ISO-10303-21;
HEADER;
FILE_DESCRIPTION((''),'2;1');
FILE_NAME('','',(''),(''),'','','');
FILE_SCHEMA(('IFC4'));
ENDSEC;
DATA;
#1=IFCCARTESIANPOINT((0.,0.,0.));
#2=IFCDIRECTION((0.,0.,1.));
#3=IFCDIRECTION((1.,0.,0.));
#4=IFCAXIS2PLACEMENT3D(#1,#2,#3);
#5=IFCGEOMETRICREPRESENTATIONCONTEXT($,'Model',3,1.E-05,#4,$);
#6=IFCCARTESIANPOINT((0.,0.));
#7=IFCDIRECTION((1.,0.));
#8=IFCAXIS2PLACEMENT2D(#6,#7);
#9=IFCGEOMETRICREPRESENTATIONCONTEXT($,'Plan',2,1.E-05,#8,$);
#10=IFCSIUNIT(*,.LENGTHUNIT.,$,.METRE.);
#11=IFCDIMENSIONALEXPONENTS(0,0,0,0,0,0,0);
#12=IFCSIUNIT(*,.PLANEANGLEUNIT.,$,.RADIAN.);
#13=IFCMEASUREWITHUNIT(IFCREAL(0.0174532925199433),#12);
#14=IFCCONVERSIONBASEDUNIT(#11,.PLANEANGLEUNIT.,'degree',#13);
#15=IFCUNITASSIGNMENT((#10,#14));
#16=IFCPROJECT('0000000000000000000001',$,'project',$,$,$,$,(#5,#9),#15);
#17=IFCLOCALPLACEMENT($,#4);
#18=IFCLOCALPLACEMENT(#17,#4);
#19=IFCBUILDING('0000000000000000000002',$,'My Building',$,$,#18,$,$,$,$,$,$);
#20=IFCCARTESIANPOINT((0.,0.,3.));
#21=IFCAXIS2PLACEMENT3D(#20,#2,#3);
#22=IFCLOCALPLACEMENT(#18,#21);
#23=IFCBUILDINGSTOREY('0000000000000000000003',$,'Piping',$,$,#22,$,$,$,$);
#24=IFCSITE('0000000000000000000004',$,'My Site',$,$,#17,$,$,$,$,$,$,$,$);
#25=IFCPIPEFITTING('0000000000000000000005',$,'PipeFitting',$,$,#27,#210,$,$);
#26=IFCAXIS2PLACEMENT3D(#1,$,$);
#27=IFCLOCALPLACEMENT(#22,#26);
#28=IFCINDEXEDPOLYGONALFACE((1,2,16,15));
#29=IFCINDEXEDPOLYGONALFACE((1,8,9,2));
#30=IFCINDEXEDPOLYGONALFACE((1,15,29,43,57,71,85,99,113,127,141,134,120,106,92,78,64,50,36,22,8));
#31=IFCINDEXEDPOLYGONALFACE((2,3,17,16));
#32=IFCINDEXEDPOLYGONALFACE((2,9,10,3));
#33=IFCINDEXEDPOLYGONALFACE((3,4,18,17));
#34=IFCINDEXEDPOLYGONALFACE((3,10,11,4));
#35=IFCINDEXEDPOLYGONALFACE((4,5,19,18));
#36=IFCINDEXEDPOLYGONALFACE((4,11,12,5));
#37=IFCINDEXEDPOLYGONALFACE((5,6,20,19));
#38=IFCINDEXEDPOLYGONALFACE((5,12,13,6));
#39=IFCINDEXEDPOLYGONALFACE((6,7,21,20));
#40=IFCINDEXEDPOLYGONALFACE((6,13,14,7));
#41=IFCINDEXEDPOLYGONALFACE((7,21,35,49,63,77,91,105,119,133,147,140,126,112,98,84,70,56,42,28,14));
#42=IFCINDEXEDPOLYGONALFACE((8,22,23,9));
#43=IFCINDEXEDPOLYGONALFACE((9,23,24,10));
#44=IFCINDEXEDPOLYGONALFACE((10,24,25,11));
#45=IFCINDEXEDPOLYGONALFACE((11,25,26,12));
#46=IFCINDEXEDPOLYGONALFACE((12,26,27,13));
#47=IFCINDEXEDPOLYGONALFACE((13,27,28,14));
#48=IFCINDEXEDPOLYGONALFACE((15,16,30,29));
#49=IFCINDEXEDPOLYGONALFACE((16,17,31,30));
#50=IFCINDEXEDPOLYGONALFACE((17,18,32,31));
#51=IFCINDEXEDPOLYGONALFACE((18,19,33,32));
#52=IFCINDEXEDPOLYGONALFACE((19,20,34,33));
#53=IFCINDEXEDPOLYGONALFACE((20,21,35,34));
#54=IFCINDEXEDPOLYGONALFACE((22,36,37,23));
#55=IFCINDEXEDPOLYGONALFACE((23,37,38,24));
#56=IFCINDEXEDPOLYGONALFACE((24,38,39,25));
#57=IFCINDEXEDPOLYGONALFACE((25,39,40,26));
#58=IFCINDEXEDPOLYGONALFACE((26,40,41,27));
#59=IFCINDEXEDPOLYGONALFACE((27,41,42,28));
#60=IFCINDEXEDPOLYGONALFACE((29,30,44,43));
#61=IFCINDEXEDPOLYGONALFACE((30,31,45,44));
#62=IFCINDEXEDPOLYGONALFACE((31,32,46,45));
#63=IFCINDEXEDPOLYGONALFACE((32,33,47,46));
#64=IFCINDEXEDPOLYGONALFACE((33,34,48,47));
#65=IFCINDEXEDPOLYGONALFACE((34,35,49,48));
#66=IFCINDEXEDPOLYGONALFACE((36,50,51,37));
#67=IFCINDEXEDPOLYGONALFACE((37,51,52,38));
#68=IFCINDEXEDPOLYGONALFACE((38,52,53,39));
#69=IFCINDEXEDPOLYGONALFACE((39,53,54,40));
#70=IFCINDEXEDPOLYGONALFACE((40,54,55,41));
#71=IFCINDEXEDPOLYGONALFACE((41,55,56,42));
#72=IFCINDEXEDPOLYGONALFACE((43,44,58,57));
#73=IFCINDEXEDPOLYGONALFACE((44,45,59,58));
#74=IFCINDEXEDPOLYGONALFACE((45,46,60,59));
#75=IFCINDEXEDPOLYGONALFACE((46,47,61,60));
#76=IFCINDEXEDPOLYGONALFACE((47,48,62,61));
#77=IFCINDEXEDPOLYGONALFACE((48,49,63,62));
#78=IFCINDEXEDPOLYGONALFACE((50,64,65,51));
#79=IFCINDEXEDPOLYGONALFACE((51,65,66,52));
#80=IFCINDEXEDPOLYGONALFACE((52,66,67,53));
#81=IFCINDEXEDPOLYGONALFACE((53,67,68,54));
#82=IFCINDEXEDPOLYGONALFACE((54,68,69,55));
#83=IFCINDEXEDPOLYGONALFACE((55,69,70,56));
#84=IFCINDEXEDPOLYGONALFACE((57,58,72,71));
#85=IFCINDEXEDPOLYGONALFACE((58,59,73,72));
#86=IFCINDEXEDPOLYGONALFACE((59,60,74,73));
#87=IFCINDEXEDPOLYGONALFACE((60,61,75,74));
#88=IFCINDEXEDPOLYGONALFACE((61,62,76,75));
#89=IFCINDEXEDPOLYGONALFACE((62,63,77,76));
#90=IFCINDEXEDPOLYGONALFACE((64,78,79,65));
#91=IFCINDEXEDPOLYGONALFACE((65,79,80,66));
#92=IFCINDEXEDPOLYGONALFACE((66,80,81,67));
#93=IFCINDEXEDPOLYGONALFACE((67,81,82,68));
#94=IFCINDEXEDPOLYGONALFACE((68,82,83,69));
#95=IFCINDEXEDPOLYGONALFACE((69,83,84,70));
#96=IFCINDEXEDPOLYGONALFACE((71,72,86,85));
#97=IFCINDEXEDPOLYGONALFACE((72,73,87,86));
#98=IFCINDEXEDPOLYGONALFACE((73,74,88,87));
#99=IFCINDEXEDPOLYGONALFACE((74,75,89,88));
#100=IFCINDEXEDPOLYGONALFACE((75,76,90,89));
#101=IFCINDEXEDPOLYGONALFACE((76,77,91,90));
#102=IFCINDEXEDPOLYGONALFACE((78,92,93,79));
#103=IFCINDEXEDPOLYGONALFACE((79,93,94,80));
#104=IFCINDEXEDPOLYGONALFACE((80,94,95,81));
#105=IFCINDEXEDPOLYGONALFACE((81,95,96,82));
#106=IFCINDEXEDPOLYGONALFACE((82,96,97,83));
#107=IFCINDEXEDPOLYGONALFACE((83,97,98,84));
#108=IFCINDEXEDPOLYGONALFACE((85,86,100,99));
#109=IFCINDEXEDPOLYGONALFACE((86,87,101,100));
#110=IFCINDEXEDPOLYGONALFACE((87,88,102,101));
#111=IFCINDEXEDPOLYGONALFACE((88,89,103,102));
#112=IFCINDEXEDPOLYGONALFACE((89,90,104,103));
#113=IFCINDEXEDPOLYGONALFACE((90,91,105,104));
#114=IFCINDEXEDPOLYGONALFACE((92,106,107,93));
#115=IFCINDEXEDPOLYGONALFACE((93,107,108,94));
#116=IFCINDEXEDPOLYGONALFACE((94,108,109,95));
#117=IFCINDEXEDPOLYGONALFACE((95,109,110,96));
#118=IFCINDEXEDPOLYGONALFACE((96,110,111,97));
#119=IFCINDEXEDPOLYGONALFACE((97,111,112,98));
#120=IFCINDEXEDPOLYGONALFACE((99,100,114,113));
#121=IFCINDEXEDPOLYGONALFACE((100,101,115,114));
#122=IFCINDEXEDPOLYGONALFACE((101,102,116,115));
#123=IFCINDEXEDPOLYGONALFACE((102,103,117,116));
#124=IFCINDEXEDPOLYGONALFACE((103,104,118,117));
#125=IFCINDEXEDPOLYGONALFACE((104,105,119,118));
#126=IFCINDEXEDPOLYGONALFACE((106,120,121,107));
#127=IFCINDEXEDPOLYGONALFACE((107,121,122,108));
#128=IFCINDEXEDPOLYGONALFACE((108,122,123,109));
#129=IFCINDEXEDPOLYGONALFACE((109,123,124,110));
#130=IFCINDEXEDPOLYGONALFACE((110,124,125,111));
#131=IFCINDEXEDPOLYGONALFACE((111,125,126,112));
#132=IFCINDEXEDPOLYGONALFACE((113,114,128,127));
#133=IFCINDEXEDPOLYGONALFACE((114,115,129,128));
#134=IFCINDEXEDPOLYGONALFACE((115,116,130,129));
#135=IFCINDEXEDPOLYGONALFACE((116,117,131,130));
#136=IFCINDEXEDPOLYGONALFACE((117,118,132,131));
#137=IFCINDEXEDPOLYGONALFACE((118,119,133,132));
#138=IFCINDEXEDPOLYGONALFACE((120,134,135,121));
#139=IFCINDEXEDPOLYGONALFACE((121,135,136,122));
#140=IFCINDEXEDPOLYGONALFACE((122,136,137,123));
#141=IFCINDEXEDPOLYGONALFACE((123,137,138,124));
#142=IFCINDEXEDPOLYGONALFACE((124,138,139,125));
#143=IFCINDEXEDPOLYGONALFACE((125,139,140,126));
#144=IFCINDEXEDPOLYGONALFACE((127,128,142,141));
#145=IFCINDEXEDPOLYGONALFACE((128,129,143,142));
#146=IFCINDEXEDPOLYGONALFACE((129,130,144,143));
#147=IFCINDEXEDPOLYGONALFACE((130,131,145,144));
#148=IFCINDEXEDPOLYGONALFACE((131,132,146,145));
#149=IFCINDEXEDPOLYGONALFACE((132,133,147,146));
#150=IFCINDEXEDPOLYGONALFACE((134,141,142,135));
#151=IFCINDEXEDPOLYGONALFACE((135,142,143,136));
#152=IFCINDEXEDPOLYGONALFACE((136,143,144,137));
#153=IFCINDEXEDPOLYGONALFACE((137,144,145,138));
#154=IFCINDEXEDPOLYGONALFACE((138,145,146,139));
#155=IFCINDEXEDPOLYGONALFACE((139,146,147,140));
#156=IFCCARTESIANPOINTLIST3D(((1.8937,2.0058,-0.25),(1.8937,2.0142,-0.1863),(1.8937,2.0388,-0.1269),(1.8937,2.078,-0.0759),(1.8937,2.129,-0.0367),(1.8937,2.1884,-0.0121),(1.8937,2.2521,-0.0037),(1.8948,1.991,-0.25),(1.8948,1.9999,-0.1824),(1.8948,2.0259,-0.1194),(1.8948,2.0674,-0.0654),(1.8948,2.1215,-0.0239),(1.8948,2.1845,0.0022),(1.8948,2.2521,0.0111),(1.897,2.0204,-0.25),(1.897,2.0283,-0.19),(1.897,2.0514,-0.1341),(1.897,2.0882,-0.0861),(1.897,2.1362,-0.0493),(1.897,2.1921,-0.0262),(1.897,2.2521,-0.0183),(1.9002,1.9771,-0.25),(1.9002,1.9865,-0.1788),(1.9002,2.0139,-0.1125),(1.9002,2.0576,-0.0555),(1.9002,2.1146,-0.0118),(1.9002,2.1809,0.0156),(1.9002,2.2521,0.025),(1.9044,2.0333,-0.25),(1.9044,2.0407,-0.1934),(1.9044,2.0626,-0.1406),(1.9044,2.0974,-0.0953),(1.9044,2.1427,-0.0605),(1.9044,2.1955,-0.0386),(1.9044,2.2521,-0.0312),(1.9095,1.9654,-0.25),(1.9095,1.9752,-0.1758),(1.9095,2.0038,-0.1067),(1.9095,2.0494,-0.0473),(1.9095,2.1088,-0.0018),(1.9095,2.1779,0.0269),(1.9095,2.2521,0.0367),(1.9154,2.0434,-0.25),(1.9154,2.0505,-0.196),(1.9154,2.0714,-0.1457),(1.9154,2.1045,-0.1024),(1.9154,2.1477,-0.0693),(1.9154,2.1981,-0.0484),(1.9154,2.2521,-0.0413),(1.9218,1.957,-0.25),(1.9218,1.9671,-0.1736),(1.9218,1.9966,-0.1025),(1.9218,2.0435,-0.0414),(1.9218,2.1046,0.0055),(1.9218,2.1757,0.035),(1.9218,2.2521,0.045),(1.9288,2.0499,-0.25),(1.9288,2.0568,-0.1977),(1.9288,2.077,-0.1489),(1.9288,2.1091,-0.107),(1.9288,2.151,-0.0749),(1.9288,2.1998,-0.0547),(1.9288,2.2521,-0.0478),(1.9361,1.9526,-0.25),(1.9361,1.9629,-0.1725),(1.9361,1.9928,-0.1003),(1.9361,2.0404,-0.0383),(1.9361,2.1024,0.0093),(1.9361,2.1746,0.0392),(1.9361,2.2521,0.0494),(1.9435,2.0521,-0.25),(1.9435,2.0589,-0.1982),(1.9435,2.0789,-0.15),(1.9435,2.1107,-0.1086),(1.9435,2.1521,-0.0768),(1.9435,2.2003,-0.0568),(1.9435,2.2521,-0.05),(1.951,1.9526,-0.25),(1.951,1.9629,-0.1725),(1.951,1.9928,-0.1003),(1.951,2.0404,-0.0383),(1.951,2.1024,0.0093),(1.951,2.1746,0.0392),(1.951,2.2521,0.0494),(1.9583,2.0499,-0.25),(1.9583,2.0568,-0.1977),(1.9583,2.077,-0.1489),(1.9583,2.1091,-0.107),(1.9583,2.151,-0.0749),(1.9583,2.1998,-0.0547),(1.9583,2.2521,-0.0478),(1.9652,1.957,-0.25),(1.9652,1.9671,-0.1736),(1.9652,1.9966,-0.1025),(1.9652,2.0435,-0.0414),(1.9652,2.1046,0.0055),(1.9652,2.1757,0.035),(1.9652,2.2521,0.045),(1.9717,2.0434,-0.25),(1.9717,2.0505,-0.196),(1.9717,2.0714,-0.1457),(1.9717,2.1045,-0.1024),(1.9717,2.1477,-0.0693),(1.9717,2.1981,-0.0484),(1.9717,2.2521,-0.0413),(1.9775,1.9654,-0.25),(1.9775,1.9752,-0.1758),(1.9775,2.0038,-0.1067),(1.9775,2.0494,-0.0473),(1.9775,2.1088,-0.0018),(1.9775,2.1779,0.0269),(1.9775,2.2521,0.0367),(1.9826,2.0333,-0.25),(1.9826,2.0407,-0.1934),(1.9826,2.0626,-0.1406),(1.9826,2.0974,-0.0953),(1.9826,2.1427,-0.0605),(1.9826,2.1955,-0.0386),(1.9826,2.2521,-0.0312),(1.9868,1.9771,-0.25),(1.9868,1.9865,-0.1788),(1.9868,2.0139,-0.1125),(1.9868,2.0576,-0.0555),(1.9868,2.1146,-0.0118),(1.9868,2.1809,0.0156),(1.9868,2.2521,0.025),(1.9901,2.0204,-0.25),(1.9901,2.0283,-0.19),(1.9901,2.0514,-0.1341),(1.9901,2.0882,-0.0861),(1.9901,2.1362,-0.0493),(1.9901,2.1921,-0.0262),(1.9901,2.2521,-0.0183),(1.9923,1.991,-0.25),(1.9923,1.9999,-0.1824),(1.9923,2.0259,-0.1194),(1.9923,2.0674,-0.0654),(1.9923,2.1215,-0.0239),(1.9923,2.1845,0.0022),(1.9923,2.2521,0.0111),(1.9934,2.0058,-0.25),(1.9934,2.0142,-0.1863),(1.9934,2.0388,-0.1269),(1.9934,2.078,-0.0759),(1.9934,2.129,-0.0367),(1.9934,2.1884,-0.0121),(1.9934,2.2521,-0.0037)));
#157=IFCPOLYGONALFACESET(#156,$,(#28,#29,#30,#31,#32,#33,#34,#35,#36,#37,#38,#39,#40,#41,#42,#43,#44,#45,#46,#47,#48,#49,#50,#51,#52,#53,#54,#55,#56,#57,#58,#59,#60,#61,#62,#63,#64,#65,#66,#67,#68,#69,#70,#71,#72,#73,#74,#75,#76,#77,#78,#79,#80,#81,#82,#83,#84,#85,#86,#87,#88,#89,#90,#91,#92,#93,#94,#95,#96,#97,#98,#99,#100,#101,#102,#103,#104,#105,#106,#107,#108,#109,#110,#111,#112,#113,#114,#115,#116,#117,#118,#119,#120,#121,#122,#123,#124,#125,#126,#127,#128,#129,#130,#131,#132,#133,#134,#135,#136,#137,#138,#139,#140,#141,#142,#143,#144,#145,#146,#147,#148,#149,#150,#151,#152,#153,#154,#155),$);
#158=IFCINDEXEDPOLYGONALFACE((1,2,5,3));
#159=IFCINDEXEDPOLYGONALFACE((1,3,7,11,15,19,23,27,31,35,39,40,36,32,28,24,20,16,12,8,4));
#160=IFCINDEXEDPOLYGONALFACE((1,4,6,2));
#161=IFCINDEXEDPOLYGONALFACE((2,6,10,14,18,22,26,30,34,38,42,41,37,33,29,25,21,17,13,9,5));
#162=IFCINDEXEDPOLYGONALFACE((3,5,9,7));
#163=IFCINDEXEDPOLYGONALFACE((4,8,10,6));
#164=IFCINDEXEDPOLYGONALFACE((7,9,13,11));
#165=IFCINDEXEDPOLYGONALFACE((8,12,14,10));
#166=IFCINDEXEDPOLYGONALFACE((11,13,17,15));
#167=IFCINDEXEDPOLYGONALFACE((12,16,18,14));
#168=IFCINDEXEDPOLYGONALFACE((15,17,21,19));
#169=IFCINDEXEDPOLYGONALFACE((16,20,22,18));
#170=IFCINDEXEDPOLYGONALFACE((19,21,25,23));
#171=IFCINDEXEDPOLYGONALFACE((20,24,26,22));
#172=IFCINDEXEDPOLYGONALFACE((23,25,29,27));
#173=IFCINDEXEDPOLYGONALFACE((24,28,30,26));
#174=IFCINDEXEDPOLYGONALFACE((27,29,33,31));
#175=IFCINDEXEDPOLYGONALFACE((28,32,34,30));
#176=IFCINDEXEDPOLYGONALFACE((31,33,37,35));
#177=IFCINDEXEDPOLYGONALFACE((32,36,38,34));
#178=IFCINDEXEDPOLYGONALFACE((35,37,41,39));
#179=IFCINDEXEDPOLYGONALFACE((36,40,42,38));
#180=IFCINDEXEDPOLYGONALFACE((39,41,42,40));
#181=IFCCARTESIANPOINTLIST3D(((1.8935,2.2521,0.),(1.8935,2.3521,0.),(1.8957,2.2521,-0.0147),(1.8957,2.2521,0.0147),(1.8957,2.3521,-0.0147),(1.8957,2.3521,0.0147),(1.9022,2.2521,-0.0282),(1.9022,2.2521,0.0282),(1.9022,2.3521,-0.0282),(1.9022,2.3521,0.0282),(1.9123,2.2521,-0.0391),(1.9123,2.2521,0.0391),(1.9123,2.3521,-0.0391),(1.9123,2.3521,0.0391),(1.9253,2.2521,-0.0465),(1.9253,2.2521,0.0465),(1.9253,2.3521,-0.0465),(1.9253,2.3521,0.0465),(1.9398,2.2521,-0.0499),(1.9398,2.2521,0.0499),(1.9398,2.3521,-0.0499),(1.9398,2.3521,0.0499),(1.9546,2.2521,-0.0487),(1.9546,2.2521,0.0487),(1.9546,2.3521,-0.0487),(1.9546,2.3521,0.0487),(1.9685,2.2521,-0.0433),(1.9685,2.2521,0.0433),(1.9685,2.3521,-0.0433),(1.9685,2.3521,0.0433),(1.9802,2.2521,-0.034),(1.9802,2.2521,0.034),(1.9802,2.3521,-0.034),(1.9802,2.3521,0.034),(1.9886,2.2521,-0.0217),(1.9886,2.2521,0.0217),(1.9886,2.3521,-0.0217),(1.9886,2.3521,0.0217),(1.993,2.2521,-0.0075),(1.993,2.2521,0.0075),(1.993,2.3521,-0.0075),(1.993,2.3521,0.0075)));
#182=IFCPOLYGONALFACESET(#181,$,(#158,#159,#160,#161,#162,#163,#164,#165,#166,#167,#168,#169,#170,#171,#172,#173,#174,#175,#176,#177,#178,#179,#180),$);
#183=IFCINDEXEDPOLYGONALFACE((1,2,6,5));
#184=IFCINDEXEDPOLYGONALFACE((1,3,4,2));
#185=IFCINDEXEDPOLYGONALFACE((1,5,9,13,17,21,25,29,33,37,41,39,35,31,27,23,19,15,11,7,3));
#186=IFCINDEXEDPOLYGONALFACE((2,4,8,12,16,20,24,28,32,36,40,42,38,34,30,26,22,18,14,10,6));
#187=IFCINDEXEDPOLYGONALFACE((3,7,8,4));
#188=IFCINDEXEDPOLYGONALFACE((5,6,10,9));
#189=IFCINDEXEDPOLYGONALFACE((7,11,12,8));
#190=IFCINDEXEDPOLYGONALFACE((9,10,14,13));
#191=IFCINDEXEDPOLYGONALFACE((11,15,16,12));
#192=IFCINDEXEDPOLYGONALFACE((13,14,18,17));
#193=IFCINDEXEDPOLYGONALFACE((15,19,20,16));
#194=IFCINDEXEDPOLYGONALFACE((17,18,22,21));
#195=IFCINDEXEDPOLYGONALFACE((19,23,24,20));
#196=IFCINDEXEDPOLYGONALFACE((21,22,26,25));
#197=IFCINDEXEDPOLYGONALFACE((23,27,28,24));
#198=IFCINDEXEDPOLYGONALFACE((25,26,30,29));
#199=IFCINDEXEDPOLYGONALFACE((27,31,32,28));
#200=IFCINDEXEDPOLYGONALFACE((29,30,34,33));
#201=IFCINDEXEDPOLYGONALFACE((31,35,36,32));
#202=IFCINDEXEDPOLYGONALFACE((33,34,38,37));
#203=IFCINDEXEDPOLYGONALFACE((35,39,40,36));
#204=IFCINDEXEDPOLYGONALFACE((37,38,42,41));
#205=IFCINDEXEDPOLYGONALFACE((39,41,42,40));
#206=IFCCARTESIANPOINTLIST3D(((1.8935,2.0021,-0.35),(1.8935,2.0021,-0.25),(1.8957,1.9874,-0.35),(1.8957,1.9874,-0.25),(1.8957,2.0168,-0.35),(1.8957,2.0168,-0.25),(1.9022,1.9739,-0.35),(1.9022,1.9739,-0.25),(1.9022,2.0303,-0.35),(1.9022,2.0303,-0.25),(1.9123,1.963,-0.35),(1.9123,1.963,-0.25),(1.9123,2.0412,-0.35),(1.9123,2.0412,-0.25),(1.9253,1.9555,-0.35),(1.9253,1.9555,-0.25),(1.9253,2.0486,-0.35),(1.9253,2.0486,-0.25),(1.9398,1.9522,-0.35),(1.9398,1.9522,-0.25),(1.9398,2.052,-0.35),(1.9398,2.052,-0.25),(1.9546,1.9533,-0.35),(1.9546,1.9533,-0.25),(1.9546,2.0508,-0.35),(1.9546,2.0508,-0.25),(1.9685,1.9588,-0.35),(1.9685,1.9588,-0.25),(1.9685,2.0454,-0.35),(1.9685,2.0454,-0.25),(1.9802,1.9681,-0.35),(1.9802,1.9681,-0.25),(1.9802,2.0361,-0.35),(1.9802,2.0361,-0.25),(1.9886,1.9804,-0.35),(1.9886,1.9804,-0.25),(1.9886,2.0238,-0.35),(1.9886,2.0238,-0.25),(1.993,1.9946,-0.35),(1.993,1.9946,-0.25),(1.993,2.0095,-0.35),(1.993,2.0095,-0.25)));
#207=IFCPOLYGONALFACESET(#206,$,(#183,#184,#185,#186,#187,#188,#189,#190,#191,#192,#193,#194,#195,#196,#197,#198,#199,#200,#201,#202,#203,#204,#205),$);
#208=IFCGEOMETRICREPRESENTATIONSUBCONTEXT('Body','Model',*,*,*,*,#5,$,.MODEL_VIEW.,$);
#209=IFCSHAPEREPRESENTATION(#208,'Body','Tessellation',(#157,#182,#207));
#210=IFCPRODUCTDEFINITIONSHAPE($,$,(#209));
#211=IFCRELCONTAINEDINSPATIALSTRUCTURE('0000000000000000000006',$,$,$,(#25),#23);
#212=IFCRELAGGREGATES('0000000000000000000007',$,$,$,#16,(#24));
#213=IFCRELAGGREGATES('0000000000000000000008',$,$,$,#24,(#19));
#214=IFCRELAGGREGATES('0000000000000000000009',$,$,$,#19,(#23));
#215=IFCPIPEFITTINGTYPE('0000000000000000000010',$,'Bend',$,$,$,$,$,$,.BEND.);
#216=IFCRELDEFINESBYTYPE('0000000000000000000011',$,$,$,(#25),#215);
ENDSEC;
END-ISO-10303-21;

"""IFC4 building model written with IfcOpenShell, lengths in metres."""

from ifc_helpers import new_model, entity, si_unit, converted_unit, frame, origin_with_axes, origin_2d_with_axis, place, context, subcontext, project, spatial, circle, extrude, source, transform, mapped, type_object, type_shapes, element, save


model = new_model("IFC4")

# Units and contexts
model_context = context("Model", 3, precision=1e-05, world=origin_with_axes())
plan_context = context("Plan", 2, precision=1e-05, world=origin_2d_with_axis())
body_context = subcontext(model_context, "Body", "Model", "MODEL_VIEW")
ifc_project = project(units=[si_unit("LENGTHUNIT", "METRE"), converted_unit("PLANEANGLEUNIT", "degree", entity("IfcReal", 0.0174532925199433), si_unit("PLANEANGLEUNIT", "RADIAN"), dimensions=[0, 0, 0, 0, 0, 0, 0])], contexts=[model_context, plan_context])

# Site, building, storey
site_placement = place(None, origin_with_axes())
site = spatial("IfcSite", under=ifc_project, at=site_placement, Name="My Site")
building_placement = place(site_placement, origin_with_axes())
building = spatial("IfcBuilding", under=site, at=building_placement, Name="My Building")
storey_placement = place(building_placement, frame((0.0, 0.0, 3.0), z_axis=(0.0, 0.0, 1.0), x_axis=(1.0, 0.0, 0.0)))
storey = spatial("IfcBuildingStorey", under=building, at=storey_placement, Name="Piping")

# Pipe fitting
pipe_fitting_type_1 = type_object("IfcPipeFittingType", Name="Bend", PredefinedType="BEND")
shared_shape = source(origin_with_axes(), body_context, "Body", "SolidModel", [
    entity("IfcSweptDiskSolid", entity("IfcIndexedPolyCurve", entity("IfcCartesianPointList3D", [[0.0, 0.0, -0.1], [0.0, -0.0732, -0.2768], [0.0, -0.25, -0.35]]), [entity("IfcArcIndex", [1, 2, 3])]), 0.05),
    extrude(circle(Radius=0.05), origin_with_axes(), (0.0, 0.0, -1.0), 0.1),
    extrude(circle(Radius=0.05), frame((0.0, -0.25, -0.35), z_axis=(0.0, -1.0, 0.0), x_axis=(1.0, 0.0, 0.0)), (0.0, 0.0, 1.0), 0.1),
])
type_shapes(pipe_fitting_type_1, [shared_shape])
for number, where, z_axis, x_axis, name in (
    (1, (1.9435, 2.3521, 0.0), (0.0, 1.0, 0.0), (-1.0, 0.0, 0.0), "PipeFitting"),
):
    element("IfcPipeFitting", number, at=place(storey_placement, frame(where, z_axis=z_axis, x_axis=x_axis)), inside=storey, type_object=pipe_fitting_type_1, Name=name, context=body_context, shape_type="MappedRepresentation", body=[
        mapped(shared_shape, transform((0.0, 0.0, 0.0), x_axis=(1.0, 0.0, 0.0), y_axis=(0.0, 1.0, 0.0), z_axis=(0.0, 0.0, 1.0), scale=1.0)),
    ])

save(model, "model.ifc")
